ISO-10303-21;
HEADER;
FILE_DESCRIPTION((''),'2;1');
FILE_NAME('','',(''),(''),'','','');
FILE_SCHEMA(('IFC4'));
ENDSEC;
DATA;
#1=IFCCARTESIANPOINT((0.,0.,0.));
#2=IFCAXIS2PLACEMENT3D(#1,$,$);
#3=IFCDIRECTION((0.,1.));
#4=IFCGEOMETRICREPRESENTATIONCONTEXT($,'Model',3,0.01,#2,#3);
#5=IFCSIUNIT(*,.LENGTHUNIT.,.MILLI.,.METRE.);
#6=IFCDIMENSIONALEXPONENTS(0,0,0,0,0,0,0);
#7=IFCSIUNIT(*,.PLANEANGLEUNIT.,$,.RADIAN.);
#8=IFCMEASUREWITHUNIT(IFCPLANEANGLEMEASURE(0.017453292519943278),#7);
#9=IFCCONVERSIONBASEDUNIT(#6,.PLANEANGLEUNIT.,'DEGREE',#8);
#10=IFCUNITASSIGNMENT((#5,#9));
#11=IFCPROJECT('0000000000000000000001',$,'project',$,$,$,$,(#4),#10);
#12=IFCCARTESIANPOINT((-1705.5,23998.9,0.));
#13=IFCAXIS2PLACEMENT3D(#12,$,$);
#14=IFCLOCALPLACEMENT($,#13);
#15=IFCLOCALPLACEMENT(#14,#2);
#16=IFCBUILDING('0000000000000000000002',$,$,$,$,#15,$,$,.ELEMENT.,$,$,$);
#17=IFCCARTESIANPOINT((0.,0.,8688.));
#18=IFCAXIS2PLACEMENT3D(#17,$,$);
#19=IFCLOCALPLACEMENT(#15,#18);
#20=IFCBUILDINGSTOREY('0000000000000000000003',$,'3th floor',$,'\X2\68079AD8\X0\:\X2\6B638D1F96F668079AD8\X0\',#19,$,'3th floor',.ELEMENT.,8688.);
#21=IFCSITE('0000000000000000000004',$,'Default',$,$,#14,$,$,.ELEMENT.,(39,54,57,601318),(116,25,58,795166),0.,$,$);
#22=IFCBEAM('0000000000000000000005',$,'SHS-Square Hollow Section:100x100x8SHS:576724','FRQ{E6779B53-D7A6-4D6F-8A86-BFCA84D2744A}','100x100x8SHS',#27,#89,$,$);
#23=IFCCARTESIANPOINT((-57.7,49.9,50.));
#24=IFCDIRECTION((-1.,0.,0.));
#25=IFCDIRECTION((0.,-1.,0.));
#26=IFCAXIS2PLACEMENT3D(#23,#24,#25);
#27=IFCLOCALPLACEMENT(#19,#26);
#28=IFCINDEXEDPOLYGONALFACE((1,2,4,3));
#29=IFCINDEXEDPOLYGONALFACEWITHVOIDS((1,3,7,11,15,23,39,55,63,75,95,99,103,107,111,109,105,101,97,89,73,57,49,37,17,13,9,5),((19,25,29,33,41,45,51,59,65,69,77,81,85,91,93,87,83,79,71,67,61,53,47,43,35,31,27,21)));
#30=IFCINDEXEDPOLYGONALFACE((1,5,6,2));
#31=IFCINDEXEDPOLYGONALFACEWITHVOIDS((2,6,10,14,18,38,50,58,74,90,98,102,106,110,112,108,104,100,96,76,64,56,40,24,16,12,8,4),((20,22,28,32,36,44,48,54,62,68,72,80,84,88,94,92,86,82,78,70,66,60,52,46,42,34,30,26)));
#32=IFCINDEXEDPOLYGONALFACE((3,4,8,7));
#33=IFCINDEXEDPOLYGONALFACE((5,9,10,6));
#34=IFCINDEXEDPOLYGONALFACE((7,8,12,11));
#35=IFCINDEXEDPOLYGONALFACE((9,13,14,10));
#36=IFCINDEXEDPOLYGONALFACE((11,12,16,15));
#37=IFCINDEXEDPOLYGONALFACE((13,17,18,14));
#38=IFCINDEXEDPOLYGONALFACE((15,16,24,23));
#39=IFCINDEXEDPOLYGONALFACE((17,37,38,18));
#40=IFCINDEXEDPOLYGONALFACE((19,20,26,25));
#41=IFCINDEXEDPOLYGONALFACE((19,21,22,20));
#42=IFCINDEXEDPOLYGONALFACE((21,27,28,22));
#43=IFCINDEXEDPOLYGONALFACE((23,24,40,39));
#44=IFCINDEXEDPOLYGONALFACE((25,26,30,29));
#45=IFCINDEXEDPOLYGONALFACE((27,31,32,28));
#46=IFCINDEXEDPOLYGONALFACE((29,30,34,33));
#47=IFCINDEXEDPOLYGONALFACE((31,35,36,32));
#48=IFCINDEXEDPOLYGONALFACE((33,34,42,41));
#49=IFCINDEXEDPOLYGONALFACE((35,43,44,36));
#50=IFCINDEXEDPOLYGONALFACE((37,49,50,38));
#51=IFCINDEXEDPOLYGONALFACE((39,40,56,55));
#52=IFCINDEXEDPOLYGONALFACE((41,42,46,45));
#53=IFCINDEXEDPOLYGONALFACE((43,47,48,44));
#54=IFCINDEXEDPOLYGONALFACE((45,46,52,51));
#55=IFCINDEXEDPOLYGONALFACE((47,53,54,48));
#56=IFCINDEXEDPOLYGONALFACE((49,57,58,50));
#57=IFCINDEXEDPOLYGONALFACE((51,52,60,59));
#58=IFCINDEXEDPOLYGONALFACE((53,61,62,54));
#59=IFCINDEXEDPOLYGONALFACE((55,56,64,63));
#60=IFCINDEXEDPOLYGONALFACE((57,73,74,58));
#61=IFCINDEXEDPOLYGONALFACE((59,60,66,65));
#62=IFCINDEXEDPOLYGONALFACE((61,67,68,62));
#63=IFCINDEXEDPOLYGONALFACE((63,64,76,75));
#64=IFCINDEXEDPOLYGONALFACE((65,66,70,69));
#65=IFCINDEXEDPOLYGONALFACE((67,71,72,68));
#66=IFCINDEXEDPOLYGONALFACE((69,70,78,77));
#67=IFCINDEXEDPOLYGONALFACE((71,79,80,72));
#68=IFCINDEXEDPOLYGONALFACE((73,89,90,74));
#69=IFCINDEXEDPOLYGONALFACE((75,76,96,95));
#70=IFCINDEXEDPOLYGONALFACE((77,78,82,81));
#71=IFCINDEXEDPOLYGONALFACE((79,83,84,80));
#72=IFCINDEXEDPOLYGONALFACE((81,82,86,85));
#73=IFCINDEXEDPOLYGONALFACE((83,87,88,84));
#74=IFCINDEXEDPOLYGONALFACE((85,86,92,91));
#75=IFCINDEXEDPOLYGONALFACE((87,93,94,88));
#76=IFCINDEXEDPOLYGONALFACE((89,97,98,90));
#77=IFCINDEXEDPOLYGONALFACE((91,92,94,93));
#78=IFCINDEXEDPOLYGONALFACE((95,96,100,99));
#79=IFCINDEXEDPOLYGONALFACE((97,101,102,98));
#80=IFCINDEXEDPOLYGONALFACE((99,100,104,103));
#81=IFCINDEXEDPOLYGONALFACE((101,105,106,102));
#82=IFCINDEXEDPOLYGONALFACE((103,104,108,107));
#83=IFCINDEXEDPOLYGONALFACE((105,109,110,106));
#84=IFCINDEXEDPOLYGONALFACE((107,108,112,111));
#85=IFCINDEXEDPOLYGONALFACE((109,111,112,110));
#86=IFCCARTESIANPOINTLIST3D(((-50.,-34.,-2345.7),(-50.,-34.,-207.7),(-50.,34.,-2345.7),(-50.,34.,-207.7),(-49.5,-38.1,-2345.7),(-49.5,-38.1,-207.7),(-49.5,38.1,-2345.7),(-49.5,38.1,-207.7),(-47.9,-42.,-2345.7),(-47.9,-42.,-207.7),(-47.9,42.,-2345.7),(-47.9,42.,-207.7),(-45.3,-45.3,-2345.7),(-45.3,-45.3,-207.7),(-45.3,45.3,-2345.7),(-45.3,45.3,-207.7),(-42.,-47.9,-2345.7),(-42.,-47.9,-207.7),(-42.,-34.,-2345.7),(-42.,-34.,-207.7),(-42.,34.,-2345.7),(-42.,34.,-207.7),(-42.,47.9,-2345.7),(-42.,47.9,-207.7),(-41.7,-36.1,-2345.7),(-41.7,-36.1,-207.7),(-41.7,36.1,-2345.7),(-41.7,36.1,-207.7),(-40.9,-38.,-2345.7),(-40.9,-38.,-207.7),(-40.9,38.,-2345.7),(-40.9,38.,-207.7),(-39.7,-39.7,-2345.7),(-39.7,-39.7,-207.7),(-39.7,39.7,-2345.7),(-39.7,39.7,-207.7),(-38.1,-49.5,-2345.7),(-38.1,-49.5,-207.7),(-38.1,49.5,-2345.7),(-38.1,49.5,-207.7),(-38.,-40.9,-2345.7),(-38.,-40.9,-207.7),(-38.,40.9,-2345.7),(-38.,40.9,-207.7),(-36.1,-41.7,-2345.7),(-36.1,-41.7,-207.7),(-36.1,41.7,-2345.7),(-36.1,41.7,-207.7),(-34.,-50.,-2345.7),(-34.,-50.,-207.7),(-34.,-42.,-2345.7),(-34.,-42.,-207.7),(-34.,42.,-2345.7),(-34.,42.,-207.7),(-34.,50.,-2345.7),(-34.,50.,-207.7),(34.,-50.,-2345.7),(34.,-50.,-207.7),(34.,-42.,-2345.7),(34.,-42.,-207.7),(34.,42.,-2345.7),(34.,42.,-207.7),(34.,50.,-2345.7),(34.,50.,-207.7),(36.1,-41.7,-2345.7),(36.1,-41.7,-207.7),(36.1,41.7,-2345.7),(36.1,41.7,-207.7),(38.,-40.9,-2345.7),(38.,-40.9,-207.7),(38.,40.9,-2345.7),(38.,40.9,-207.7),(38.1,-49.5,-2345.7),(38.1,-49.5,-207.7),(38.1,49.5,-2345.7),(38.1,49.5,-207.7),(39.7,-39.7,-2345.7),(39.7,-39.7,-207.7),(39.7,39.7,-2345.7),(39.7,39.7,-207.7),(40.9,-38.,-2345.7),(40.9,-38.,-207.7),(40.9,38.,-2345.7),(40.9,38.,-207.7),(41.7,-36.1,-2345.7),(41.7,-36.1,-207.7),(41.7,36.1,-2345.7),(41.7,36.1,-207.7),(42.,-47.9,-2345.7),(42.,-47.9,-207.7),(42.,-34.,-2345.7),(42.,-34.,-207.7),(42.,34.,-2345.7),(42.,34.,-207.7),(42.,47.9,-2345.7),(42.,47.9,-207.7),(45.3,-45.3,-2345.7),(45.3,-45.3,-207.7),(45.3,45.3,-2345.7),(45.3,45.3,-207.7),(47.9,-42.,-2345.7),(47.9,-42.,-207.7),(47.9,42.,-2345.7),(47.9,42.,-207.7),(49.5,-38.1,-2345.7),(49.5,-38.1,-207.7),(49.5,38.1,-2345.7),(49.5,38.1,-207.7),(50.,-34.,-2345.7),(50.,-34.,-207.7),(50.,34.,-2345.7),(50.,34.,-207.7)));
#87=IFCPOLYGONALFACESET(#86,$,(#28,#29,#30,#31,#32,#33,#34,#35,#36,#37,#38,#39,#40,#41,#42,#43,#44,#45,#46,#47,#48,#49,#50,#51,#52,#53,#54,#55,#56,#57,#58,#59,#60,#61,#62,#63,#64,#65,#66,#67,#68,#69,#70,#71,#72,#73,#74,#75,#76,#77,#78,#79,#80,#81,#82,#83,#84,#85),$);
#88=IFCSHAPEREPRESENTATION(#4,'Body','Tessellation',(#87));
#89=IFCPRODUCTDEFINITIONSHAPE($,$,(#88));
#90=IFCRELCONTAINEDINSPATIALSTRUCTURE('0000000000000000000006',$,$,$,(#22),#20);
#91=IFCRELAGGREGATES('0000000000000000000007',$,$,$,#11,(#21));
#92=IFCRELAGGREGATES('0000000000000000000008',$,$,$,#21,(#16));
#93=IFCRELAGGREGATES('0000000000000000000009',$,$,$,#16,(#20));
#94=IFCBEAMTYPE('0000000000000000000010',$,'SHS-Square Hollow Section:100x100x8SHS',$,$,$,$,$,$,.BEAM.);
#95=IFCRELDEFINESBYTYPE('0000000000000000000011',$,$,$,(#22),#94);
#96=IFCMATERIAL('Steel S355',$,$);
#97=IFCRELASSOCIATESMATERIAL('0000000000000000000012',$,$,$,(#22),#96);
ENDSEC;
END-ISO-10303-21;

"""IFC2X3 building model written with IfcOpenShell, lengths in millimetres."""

from ifc_helpers import new_model, entity, si_unit, converted_unit, direction, frame, origin, origin_2d, place, context, project, spatial, hollow_rectangle, extrude, clip, halfspace, material, type_object, element, save


model = new_model("IFC2X3")

# Units and contexts
model_context = context("Model", 3, precision=0.01, world=origin(), true_north=direction((0.0, 1.0)))
ifc_project = project(units=[si_unit("LENGTHUNIT", "METRE", prefix="MILLI"), converted_unit("PLANEANGLEUNIT", "DEGREE", entity("IfcPlaneAngleMeasure", 0.017453292519943278), si_unit("PLANEANGLEUNIT", "RADIAN"), dimensions=[0, 0, 0, 0, 0, 0, 0])], contexts=[model_context])

# Site, building, storey
site_placement = place(None, frame((-1705.5, 23998.9, 0.0)))
site = spatial("IfcSite", under=ifc_project, at=site_placement, Name="Default", CompositionType="ELEMENT", RefLatitude=(39, 54, 57, 601318), RefLongitude=(116, 25, 58, 795166), RefElevation=0.0)
building_placement = place(site_placement, origin())
building = spatial("IfcBuilding", under=site, at=building_placement, CompositionType="ELEMENT")
storey_placement = place(building_placement, frame((0.0, 0.0, 8688.0)))
storey = spatial("IfcBuildingStorey", under=building, at=storey_placement, Name="3th floor", ObjectType="标高:正负零标高", LongName="3th floor", CompositionType="ELEMENT", Elevation=8688.0)

# Shared definitions
ifc_material_1 = material(Name="Steel S355")

# Beam
beam_type = type_object("IfcBeamType", Name="SHS-Square Hollow Section:100x100x8SHS", PredefinedType="BEAM")
beam_placement = place(storey_placement, frame((-57.7, 49.9, 50.0), z_axis=(-1.0, 0.0, 0.0), x_axis=(0.0, -1.0, 0.0)))
element("IfcBeam", 1, at=beam_placement, inside=storey, type_object=beam_type, material=ifc_material_1, Name="SHS-Square Hollow Section:100x100x8SHS:576724", Description="FRQ{E6779B53-D7A6-4D6F-8A86-BFCA84D2744A}", ObjectType="100x100x8SHS", context=model_context, shape_type="Clipping", body=[
    clip(clip(extrude(hollow_rectangle(XDim=100.0, YDim=100.0, WallThickness=8.0, InnerFilletRadius=8.0, OuterFilletRadius=16.0, at=origin_2d()), origin(), (0.0, 0.0, -1.0), 2551.4), halfspace(frame((49.9, -8738.0, -2345.7), z_axis=(0.0, 0.0, 1.0), x_axis=(1.0, 0.0, 0.0)), True)), halfspace(frame((49.9, -8738.0, -207.7), z_axis=(0.0, 0.0, -1.0), x_axis=(-1.0, 0.0, 0.0)), True)),
])

save(model, "model.ifc")
